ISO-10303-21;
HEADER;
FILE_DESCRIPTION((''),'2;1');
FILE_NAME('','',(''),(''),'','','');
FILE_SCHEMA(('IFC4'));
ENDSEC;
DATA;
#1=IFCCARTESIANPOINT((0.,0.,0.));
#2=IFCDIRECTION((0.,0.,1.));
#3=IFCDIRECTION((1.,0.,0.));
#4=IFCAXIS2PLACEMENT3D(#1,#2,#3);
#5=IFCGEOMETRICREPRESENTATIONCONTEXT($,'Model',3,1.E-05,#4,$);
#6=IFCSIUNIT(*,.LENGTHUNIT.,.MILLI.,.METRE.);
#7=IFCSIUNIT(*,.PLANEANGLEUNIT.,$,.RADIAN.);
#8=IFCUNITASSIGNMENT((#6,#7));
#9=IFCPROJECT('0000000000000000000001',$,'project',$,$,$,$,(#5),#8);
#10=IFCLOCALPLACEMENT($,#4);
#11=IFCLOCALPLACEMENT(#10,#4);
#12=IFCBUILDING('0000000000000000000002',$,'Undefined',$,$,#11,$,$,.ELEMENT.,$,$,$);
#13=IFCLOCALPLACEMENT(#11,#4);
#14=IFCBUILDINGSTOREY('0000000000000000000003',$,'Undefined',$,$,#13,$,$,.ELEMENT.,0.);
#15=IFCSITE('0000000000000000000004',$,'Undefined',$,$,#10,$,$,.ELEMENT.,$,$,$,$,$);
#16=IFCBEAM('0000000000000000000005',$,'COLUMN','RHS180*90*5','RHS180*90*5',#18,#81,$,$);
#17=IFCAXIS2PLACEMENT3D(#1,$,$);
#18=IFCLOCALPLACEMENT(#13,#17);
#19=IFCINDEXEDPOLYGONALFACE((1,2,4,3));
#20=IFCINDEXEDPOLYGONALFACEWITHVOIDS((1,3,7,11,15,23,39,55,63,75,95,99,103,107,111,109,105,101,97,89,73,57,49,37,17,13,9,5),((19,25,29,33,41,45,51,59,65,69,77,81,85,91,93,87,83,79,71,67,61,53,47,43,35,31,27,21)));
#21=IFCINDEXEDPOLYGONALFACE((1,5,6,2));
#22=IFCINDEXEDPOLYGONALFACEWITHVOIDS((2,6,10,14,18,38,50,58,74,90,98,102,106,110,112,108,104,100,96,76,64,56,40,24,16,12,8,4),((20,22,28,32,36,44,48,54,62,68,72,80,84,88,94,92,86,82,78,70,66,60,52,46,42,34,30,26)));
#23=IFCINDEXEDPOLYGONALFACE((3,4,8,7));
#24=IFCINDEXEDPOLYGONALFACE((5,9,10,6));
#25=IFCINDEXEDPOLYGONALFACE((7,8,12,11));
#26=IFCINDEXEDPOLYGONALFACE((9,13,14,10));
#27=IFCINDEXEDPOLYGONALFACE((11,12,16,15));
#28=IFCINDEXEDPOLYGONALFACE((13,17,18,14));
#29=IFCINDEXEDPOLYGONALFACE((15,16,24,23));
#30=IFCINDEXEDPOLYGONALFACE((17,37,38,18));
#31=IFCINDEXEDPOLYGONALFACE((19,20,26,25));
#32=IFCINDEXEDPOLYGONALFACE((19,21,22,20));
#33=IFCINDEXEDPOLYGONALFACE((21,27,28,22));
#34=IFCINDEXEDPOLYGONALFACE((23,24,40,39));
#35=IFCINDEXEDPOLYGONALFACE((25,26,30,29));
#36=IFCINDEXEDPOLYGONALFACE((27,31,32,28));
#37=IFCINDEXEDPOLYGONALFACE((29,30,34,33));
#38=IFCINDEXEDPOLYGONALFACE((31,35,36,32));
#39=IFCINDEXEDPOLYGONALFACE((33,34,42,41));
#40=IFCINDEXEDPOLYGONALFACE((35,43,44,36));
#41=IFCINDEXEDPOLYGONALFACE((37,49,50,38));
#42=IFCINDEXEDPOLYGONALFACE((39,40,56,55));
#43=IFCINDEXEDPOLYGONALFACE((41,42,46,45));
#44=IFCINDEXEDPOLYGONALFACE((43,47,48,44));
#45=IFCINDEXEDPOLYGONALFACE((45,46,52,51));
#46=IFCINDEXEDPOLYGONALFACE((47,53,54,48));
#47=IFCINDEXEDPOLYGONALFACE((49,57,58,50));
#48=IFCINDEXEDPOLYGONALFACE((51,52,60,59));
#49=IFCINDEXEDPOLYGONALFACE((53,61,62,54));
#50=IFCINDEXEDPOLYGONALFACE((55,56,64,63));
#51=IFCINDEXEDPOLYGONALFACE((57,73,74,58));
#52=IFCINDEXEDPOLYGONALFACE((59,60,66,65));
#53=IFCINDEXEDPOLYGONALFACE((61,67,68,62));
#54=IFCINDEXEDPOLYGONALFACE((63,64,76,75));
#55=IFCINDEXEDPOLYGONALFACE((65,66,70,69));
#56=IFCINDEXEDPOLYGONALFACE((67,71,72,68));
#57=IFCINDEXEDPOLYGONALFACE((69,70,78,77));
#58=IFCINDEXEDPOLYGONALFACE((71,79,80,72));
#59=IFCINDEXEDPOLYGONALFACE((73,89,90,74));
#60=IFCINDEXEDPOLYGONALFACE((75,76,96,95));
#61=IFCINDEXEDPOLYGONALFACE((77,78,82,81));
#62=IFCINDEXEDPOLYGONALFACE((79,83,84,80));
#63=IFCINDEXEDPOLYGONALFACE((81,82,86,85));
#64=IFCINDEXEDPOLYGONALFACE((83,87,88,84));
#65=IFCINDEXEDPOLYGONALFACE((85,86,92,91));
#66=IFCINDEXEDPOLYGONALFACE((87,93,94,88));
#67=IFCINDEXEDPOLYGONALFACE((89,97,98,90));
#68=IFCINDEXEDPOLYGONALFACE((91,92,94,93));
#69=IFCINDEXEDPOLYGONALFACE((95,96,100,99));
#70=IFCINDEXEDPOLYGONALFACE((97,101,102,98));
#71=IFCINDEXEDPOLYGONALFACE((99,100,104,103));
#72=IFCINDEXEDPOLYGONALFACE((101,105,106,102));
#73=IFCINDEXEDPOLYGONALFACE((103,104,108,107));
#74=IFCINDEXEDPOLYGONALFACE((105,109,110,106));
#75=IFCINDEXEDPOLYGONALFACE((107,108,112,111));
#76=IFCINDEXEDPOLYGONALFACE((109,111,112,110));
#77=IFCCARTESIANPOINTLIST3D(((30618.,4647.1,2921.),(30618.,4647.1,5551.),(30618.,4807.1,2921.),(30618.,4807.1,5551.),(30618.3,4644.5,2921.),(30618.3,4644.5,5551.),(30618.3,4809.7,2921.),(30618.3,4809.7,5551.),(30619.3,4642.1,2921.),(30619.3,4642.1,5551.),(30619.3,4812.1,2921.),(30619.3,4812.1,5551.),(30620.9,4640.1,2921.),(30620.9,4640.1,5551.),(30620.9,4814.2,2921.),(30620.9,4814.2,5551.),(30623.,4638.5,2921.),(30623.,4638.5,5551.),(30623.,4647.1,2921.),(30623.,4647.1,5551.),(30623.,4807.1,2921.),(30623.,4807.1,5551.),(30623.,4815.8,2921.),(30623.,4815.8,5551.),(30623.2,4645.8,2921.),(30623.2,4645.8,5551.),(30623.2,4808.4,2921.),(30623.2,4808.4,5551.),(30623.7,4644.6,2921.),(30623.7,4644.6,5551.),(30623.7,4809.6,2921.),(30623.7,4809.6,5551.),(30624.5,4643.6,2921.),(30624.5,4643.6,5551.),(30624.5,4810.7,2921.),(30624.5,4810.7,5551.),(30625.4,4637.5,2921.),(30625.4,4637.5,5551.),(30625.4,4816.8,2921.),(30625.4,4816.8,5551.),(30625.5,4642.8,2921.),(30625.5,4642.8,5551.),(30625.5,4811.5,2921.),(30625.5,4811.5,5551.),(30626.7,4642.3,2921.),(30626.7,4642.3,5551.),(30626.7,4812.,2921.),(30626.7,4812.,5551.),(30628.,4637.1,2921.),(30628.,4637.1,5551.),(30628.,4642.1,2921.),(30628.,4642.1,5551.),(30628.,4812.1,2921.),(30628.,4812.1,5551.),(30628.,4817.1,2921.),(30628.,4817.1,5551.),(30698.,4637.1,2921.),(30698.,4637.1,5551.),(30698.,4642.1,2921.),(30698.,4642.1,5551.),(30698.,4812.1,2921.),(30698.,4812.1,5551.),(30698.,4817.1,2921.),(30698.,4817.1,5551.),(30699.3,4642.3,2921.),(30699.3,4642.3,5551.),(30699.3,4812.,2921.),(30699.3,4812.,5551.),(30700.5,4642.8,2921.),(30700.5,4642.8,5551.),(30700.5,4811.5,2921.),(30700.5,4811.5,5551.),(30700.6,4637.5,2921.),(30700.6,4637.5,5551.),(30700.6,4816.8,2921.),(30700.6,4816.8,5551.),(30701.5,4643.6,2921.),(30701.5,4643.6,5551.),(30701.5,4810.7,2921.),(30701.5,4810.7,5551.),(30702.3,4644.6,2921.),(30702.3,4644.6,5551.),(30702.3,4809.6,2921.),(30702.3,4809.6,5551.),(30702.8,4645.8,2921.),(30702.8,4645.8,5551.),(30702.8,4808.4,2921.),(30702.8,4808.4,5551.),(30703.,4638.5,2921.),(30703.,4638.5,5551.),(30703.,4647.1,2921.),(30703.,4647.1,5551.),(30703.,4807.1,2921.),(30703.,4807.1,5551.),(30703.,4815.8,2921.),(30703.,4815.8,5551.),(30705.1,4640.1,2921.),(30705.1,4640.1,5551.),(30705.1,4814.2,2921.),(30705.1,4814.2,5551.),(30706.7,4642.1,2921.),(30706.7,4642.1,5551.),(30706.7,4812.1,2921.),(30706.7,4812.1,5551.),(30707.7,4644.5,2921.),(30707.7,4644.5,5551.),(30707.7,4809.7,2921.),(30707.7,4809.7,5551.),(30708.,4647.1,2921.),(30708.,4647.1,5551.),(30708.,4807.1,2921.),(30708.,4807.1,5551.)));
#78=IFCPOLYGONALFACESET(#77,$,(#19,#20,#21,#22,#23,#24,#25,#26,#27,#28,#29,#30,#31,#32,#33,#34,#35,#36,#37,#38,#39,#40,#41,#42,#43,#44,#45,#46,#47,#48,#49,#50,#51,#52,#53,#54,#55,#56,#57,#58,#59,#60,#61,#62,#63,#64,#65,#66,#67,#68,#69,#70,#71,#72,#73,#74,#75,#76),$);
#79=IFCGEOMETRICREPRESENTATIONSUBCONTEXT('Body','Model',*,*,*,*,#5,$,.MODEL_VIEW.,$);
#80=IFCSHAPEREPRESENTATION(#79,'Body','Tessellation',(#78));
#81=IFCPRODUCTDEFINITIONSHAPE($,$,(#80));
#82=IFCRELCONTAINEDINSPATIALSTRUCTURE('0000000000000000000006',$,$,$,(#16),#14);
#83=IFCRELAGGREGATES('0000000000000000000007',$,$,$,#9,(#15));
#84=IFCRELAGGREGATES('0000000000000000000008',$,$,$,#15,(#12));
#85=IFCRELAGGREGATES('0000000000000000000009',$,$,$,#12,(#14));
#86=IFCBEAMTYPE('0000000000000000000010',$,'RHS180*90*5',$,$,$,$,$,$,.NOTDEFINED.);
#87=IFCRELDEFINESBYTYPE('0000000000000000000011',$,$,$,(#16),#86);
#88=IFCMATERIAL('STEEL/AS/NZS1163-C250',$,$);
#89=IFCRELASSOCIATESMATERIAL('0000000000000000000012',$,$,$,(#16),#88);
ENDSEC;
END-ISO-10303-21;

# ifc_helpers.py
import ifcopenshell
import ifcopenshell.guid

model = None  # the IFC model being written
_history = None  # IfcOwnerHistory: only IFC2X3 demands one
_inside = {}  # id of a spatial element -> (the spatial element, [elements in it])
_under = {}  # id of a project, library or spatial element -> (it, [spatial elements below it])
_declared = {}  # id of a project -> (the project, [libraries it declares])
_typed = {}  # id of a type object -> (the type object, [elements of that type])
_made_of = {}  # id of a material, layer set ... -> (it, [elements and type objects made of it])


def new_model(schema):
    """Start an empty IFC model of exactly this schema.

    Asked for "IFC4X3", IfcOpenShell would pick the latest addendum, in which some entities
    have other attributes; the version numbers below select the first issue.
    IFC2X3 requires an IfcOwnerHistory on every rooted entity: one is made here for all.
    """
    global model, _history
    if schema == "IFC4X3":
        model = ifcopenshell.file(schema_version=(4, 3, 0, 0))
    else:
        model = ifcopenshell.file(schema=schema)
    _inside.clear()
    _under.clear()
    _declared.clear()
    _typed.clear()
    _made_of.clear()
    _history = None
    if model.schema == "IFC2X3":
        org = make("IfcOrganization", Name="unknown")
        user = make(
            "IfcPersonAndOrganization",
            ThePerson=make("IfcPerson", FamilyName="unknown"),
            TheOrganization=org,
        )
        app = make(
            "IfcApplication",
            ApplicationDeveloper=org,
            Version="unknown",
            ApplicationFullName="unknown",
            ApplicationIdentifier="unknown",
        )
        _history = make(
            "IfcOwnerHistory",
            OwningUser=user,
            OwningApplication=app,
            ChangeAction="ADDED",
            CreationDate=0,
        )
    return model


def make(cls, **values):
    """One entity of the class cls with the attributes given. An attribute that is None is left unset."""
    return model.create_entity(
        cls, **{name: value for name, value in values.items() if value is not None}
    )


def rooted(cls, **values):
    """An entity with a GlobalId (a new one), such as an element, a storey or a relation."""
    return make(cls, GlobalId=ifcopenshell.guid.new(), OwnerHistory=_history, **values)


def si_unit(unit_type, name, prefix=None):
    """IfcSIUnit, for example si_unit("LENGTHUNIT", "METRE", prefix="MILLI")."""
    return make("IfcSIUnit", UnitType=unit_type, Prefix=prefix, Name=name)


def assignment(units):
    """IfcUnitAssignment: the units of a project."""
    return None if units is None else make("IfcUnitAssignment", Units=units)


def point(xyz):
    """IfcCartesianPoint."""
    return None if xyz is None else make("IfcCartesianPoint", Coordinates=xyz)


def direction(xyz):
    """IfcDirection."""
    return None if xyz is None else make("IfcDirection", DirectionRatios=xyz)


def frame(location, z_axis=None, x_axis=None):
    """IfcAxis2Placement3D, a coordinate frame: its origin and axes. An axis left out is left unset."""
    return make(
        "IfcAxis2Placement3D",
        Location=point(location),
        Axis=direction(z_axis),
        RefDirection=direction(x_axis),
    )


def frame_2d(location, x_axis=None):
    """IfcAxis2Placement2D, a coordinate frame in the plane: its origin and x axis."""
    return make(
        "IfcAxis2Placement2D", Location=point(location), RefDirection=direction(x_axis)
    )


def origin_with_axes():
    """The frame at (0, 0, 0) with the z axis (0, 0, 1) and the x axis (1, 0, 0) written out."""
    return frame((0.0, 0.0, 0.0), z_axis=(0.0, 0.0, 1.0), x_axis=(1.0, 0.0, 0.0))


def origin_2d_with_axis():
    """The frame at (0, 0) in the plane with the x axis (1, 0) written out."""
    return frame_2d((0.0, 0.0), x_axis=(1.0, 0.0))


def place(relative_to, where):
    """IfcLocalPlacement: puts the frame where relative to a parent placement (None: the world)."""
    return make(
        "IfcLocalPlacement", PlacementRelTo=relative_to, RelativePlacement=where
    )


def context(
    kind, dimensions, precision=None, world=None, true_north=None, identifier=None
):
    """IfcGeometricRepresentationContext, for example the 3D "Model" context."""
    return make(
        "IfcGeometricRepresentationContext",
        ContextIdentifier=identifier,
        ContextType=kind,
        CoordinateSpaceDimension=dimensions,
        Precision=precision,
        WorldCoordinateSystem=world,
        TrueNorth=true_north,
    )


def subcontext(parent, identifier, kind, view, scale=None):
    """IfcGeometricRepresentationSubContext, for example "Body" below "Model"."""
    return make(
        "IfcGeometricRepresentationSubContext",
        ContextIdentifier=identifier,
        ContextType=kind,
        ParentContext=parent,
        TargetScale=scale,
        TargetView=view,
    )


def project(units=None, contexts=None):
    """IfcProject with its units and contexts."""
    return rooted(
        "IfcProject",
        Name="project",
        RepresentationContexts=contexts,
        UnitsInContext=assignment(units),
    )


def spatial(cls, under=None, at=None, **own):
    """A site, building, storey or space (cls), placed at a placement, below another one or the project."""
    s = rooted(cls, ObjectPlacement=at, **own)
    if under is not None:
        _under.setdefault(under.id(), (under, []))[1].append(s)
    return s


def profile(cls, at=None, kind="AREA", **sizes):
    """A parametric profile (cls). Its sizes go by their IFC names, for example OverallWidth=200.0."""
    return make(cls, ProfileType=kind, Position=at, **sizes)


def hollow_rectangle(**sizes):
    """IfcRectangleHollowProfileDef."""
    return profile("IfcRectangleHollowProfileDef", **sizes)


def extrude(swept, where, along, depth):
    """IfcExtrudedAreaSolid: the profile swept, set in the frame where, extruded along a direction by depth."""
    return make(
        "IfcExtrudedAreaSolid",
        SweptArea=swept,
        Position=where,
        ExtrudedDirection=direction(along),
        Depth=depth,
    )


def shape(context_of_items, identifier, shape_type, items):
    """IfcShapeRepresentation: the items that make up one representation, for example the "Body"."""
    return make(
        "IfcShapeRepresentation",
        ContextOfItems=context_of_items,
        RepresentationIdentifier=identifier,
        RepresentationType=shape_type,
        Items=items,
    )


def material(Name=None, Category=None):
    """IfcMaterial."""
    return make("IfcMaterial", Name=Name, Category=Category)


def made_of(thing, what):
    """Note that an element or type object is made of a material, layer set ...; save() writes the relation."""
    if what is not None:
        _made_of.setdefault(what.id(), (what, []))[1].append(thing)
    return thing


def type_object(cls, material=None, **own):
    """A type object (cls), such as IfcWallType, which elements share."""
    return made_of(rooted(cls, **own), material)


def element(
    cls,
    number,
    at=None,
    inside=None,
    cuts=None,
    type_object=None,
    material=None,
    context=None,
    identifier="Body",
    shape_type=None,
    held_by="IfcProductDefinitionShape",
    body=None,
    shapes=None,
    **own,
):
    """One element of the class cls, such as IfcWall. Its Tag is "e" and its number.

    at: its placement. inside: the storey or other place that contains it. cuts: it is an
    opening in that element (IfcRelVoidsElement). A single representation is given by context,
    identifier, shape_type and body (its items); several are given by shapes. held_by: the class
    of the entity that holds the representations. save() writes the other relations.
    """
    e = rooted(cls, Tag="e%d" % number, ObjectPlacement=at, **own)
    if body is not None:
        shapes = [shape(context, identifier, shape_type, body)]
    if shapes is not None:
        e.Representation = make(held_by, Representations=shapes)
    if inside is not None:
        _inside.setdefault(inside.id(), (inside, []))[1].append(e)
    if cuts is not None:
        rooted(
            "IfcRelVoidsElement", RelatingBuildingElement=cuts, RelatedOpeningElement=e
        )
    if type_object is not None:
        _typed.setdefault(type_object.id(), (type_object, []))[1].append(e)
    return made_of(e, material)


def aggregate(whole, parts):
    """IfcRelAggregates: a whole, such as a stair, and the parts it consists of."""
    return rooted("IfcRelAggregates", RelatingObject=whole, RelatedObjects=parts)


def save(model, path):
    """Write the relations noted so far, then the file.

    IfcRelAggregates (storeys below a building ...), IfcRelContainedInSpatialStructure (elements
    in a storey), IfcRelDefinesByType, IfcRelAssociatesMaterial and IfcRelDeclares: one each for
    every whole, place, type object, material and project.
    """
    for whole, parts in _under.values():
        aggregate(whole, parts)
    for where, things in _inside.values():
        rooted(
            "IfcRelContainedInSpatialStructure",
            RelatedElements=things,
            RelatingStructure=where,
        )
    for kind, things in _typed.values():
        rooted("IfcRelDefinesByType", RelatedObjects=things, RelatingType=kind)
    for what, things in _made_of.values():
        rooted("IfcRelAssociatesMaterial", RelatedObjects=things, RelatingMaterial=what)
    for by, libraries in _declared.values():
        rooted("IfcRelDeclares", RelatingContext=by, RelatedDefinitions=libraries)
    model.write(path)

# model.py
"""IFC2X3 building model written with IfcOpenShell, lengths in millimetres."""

from ifc_helpers import new_model, si_unit, frame, origin_with_axes, origin_2d_with_axis, place, context, subcontext, project, spatial, hollow_rectangle, extrude, material, type_object, element, save


model = new_model("IFC2X3")

# Units and contexts
model_context = context("Model", 3, precision=1e-05, world=origin_with_axes())
body_context = subcontext(model_context, "Body", "Model", "MODEL_VIEW")
ifc_project = project(units=[si_unit("LENGTHUNIT", "METRE", prefix="MILLI"), si_unit("PLANEANGLEUNIT", "RADIAN")], contexts=[model_context])

# Site, building, storey
site_placement = place(None, origin_with_axes())
site = spatial("IfcSite", under=ifc_project, at=site_placement, Name="Undefined", CompositionType="ELEMENT")
building_placement = place(site_placement, origin_with_axes())
building = spatial("IfcBuilding", under=site, at=building_placement, Name="Undefined", CompositionType="ELEMENT")
storey_placement = place(building_placement, origin_with_axes())
storey = spatial("IfcBuildingStorey", under=building, at=storey_placement, Name="Undefined", CompositionType="ELEMENT", Elevation=0.0)

# Shared definitions
ifc_material_1 = material(Name="STEEL/AS/NZS1163-C250")

# Beam
beam_type_1 = type_object("IfcBeamType", Name="RHS180*90*5", PredefinedType="NOTDEFINED")
beam_1_placement = place(storey_placement, frame((30663.0, 4727.1, 5551.0), z_axis=(0.0, 1.0, 0.0), x_axis=(0.0, 0.0, -1.0)))
element("IfcBeam", 1, at=beam_1_placement, inside=storey, type_object=beam_type_1, material=ifc_material_1, Name="COLUMN", Description="RHS180*90*5", ObjectType="RHS180*90*5", context=body_context, shape_type="SweptSolid", body=[
    extrude(hollow_rectangle(XDim=90.0, YDim=180.0, WallThickness=5.0, InnerFilletRadius=5.0, OuterFilletRadius=10.0, at=origin_2d_with_axis()), frame((2630.0, 0.0, 0.0), z_axis=(-1.0, 0.0, 0.0), x_axis=(0.0, -1.0, 0.0)), (0.0, 0.0, 1.0), 2630.0),
])

save(model, "model.ifc")
